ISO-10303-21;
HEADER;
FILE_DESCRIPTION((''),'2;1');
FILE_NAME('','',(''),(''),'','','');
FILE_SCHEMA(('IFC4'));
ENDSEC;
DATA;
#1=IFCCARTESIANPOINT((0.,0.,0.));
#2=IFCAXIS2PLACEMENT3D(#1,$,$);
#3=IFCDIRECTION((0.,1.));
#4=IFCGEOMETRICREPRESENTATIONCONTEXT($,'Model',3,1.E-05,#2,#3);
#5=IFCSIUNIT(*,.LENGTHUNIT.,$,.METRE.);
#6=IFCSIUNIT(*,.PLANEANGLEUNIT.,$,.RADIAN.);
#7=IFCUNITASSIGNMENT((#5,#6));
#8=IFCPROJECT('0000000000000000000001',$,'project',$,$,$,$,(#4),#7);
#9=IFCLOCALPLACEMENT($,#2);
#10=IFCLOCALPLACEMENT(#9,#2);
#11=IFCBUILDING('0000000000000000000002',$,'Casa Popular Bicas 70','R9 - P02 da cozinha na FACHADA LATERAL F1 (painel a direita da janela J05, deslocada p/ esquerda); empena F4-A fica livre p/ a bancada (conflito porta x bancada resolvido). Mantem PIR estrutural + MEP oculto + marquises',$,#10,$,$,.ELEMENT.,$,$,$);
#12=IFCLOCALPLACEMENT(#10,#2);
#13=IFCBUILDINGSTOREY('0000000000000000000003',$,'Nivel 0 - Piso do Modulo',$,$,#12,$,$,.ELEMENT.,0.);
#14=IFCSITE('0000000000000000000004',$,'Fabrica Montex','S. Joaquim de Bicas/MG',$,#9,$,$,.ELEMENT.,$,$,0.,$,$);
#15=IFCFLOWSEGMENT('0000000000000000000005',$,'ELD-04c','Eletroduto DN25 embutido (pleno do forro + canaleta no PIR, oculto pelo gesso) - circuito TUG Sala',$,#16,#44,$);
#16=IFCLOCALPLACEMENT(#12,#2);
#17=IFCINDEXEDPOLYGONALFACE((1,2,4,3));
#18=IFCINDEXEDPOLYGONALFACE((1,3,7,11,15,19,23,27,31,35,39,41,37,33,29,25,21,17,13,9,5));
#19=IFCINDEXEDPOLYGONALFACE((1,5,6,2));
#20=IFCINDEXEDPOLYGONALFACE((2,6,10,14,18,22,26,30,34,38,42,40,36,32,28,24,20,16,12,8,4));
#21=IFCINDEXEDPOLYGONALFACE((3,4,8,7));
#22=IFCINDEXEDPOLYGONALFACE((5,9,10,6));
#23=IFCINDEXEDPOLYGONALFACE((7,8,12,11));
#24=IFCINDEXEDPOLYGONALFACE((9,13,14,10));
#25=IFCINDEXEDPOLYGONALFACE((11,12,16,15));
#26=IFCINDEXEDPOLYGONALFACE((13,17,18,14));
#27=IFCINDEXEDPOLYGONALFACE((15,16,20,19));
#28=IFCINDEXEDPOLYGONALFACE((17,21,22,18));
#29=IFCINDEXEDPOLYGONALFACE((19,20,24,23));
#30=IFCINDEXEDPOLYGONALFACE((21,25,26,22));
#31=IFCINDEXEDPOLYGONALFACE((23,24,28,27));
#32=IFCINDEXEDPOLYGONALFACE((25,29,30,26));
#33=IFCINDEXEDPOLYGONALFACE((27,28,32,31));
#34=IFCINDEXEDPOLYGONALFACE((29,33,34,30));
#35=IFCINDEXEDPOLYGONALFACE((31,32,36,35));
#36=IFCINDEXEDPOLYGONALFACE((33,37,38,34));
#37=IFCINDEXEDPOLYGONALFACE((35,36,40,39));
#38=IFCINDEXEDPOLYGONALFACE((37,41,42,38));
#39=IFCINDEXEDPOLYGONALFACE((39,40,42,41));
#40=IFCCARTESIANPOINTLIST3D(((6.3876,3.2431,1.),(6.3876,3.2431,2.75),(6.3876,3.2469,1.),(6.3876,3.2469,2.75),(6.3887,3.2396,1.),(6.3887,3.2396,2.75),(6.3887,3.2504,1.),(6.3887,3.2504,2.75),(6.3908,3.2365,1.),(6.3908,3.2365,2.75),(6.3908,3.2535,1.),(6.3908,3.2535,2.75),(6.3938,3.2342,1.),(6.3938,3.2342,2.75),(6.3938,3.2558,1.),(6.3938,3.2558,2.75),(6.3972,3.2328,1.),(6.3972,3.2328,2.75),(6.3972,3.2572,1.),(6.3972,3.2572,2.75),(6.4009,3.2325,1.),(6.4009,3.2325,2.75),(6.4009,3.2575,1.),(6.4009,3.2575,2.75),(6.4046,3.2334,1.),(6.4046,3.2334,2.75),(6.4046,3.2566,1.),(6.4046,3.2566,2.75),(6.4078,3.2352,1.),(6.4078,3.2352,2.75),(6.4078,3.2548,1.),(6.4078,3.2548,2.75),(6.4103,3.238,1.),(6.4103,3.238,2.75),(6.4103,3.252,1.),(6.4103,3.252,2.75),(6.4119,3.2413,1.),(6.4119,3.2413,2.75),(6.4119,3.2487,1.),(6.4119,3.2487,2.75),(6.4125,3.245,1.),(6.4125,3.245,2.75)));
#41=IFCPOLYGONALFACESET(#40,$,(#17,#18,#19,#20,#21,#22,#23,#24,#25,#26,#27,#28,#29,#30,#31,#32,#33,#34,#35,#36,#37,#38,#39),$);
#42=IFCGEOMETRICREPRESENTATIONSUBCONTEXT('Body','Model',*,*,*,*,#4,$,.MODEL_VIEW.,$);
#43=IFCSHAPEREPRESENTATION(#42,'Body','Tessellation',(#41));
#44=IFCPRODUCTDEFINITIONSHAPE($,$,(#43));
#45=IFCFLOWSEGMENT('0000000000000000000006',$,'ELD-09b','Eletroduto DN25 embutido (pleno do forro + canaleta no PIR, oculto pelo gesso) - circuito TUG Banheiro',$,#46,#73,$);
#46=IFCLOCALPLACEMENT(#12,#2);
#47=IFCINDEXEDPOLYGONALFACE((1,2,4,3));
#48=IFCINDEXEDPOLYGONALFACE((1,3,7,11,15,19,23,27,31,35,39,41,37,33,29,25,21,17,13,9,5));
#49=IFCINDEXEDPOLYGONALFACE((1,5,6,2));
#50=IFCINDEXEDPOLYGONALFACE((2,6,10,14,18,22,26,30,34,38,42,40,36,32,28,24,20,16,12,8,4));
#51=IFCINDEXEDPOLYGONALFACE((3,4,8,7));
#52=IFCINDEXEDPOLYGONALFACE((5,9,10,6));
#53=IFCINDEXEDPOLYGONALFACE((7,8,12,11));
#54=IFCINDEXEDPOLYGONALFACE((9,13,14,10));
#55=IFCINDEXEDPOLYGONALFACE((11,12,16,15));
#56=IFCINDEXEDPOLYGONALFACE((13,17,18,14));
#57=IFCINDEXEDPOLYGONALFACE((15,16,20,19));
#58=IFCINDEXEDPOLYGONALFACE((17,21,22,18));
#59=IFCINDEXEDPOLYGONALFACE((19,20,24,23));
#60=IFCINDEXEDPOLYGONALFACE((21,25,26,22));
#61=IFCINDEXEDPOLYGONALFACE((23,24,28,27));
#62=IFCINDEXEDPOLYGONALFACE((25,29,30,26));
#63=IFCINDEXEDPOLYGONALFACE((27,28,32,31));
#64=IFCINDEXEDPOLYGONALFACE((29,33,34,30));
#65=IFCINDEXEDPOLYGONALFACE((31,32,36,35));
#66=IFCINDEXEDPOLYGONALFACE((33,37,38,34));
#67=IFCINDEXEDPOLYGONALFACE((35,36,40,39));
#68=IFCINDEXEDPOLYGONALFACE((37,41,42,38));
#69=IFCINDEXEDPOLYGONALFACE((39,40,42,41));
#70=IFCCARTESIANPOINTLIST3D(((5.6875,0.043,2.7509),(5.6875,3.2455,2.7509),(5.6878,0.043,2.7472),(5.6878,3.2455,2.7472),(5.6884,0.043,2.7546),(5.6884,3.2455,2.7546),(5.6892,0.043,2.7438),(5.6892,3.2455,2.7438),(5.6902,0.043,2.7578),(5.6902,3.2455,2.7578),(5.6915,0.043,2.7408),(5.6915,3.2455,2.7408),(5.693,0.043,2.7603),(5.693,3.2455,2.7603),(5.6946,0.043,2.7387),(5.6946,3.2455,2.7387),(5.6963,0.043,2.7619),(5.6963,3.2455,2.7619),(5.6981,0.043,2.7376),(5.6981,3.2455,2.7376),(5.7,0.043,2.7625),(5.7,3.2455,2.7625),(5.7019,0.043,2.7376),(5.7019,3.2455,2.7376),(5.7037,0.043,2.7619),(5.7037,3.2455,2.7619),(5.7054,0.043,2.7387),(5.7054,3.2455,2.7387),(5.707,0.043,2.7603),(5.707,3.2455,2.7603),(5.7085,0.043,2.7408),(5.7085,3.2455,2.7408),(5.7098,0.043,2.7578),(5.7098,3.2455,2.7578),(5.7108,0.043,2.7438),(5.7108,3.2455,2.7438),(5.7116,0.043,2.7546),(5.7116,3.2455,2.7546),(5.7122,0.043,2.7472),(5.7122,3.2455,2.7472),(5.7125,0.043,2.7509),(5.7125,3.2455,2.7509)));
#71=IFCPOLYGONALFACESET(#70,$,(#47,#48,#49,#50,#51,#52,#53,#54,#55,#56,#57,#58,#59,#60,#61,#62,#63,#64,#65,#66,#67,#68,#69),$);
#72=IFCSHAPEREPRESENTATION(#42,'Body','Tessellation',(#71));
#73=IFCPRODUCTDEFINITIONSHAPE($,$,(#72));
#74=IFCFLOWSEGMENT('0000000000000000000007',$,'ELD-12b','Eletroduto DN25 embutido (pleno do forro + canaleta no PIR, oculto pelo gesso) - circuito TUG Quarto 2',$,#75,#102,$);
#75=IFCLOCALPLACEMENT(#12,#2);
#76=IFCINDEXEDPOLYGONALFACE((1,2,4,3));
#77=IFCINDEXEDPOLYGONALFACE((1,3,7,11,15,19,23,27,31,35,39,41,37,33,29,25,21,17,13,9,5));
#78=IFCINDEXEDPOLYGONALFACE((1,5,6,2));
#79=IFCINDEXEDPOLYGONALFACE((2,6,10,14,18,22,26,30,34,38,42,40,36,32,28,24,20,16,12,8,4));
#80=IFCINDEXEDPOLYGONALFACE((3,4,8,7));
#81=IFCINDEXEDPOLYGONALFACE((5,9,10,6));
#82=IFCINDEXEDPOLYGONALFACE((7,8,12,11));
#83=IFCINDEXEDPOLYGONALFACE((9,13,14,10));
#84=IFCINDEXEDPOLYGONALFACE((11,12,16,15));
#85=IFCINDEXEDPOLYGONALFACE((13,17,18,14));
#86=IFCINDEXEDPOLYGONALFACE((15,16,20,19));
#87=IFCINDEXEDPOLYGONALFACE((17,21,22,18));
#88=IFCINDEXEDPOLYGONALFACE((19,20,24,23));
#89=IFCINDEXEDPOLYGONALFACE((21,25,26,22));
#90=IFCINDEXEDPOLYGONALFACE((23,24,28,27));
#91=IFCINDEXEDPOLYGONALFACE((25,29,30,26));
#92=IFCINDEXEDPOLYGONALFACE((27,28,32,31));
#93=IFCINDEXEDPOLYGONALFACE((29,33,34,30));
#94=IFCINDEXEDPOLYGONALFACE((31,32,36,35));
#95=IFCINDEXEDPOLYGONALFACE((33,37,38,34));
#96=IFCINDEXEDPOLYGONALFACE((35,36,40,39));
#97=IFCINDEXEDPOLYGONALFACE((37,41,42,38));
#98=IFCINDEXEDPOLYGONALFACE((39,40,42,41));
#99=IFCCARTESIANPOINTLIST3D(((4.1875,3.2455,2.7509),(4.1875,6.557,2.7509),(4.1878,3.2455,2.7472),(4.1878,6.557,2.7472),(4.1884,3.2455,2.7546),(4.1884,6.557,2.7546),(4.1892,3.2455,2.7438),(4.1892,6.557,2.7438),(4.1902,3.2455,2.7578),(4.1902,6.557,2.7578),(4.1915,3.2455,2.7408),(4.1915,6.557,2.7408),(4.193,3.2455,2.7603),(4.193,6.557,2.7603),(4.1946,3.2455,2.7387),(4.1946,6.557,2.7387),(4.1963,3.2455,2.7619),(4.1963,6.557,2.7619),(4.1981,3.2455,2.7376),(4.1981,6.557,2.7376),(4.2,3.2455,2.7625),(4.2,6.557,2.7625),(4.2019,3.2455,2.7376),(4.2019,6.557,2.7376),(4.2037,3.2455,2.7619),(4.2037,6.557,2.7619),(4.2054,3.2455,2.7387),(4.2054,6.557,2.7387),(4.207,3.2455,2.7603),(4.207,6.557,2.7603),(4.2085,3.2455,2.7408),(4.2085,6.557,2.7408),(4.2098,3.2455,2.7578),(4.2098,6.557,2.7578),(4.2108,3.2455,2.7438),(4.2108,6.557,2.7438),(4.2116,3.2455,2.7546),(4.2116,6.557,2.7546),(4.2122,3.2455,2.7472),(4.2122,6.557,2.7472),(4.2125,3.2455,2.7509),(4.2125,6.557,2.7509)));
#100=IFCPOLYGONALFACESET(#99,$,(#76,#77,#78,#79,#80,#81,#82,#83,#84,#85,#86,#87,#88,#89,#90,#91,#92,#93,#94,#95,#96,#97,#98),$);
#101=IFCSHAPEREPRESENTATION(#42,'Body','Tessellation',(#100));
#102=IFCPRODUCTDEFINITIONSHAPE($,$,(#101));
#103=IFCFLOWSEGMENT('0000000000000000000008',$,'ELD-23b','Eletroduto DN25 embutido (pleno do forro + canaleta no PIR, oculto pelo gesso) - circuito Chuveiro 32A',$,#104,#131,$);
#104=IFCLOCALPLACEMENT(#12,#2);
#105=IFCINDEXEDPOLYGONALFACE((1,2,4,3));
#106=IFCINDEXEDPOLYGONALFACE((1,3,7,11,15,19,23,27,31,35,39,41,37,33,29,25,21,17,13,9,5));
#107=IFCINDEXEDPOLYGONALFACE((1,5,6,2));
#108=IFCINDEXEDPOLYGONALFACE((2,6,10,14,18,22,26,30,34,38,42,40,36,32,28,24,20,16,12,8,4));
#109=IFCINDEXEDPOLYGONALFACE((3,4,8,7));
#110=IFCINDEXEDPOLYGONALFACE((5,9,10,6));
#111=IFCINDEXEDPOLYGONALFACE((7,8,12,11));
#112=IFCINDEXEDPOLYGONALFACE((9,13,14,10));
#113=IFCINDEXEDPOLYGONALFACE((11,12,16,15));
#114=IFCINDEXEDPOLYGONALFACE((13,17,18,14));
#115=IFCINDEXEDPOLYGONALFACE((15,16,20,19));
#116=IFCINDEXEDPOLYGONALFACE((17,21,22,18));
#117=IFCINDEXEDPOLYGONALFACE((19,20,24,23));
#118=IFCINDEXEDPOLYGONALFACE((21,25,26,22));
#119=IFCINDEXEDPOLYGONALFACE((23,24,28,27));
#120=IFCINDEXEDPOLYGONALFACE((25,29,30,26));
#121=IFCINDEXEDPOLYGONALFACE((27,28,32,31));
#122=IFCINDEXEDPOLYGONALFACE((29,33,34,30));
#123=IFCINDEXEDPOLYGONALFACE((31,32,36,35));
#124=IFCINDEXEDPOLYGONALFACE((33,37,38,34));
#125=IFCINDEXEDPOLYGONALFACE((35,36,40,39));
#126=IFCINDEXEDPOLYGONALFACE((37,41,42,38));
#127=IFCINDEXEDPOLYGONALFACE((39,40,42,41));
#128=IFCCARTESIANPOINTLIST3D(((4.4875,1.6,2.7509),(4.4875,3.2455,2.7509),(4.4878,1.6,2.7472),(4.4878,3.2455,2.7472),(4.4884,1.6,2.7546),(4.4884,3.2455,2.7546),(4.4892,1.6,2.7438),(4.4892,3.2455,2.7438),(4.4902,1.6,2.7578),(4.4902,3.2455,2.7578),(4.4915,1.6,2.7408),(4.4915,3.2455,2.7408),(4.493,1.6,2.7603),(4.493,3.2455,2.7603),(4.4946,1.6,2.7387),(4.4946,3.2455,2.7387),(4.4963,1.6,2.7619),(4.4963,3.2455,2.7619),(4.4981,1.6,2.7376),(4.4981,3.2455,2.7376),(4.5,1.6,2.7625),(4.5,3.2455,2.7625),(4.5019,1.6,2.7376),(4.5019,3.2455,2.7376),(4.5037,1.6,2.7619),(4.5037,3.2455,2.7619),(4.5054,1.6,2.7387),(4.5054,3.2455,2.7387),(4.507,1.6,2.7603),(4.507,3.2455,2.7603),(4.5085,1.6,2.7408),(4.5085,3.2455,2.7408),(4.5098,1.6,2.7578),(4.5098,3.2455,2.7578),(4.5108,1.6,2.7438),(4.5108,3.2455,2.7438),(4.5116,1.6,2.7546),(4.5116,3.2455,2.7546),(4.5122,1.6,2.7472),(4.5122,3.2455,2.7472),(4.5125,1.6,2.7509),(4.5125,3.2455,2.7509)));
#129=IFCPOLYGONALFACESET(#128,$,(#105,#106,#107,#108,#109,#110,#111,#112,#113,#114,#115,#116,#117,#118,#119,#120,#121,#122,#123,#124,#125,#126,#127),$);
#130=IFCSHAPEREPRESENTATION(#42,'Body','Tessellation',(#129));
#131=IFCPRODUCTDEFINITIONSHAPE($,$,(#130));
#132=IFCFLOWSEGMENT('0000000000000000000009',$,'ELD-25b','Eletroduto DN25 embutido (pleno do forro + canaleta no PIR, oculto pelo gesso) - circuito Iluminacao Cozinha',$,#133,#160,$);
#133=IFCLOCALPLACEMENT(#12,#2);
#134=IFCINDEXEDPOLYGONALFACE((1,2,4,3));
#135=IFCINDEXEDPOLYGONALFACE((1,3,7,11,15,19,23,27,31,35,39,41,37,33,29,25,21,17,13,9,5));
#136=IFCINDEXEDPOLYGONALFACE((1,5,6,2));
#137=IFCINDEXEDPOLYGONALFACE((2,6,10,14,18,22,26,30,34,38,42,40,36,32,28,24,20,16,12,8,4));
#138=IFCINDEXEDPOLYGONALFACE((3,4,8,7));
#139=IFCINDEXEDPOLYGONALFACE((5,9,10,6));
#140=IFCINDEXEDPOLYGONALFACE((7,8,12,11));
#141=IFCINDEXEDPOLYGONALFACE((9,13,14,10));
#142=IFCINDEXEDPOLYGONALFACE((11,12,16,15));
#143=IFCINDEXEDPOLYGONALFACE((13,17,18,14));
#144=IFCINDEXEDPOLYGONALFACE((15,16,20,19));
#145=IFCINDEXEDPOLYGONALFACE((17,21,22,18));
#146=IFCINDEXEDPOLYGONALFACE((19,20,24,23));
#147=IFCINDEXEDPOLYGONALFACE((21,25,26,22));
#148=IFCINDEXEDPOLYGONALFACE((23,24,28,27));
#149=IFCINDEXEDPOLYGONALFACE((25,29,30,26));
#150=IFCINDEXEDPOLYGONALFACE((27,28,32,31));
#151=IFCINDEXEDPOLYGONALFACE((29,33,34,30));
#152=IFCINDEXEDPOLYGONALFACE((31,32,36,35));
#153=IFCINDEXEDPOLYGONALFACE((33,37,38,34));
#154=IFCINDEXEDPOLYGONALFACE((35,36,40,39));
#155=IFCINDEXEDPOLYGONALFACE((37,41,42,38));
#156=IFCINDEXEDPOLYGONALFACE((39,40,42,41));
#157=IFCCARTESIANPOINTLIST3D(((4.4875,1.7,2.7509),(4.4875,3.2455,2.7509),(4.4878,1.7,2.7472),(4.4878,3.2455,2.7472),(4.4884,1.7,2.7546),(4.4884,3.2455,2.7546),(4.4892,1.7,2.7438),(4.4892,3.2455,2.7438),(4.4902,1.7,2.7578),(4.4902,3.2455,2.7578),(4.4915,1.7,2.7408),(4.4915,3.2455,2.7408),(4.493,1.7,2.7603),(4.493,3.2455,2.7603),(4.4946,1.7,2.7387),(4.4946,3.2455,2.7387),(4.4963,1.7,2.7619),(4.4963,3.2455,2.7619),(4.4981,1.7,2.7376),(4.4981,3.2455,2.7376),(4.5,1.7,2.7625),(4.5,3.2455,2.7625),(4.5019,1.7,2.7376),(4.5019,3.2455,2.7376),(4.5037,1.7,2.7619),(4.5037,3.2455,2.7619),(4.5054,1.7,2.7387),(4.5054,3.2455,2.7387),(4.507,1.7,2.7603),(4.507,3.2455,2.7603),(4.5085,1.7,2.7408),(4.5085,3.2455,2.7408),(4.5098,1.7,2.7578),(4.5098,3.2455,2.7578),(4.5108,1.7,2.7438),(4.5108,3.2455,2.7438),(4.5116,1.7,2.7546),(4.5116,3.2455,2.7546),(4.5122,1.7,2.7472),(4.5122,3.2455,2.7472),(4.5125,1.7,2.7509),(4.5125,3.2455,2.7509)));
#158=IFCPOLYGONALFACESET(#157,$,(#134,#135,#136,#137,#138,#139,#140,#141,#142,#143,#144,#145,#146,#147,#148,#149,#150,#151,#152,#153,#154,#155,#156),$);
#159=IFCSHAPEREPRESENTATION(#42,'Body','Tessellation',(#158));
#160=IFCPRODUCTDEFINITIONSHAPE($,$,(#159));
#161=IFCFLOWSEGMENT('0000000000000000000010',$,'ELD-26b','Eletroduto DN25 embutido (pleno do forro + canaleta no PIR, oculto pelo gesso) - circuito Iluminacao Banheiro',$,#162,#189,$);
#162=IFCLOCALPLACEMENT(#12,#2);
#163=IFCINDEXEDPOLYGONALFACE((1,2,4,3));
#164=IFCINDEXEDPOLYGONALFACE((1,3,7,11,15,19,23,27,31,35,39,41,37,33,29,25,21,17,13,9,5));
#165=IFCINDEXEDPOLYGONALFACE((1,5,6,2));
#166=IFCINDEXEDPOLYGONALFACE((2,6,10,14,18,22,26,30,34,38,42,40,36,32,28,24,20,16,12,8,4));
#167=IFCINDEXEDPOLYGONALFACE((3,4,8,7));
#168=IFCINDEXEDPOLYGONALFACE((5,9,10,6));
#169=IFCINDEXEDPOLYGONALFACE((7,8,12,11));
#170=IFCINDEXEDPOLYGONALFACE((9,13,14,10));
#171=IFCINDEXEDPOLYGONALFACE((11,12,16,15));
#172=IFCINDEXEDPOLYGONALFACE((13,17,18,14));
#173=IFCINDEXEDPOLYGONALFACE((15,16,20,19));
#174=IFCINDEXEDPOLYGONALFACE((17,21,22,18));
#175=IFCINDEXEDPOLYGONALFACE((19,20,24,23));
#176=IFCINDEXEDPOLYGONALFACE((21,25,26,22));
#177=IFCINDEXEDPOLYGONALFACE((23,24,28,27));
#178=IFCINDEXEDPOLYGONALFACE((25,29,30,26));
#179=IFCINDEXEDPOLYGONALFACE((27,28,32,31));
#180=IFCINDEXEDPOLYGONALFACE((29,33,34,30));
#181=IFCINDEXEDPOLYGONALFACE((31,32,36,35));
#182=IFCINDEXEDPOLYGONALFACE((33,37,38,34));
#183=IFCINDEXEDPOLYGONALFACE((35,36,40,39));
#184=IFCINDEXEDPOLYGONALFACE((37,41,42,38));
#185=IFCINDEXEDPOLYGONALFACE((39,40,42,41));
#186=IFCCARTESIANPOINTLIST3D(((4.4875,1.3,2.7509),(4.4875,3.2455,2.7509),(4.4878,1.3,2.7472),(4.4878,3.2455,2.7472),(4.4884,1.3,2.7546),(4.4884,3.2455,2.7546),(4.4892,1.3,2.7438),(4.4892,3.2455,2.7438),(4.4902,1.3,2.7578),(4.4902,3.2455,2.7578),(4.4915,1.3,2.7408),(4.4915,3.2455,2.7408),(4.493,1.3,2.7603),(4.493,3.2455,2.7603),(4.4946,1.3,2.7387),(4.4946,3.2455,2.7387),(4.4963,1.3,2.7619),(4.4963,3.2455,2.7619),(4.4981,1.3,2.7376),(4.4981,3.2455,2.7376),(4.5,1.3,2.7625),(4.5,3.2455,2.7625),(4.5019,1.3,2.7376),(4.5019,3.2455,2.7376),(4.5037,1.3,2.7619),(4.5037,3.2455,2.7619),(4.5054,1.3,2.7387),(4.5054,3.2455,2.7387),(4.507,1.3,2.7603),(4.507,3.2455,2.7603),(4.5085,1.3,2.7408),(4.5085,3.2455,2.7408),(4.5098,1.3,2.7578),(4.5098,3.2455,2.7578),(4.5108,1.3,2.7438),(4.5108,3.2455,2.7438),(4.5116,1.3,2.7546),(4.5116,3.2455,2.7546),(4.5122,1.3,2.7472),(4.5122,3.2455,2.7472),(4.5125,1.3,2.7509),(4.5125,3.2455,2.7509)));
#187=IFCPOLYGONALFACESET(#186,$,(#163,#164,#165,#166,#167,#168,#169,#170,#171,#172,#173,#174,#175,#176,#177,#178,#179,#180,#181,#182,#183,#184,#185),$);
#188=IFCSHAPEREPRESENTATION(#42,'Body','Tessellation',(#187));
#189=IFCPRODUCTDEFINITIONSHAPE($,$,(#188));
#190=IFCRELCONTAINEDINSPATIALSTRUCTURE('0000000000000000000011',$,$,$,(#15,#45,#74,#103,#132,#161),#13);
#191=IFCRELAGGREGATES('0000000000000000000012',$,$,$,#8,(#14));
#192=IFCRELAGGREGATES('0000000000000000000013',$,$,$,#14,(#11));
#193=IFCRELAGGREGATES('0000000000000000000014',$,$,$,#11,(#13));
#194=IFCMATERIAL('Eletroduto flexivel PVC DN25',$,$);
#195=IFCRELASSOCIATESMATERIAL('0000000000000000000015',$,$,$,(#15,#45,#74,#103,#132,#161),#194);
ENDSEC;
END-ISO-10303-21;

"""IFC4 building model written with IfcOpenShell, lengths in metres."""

from ifc_helpers import new_model, si_unit, direction, frame, origin, origin_2d, place, context, subcontext, project, spatial, circle, extrude, material, element, save


model = new_model("IFC4")

# Units and contexts
model_context = context("Model", 3, precision=1e-05, world=origin(), true_north=direction((0.0, 1.0)))
body_context = subcontext(model_context, "Body", "Model", "MODEL_VIEW")
ifc_project = project(units=[si_unit("LENGTHUNIT", "METRE"), si_unit("PLANEANGLEUNIT", "RADIAN")], contexts=[model_context])

# Site, building, storey
site_placement = place(None, origin())
site = spatial("IfcSite", under=ifc_project, at=site_placement, Name="Fabrica Montex", Description="S. Joaquim de Bicas/MG", CompositionType="ELEMENT", RefElevation=0.0)
building_placement = place(site_placement, origin())
building = spatial("IfcBuilding", under=site, at=building_placement, Name="Casa Popular Bicas 70", Description="R9 - P02 da cozinha na FACHADA LATERAL F1 (painel a direita da janela J05, deslocada p/ esquerda); empena F4-A fica livre p/ a bancada (conflito porta x bancada resolvido). Mantem PIR estrutural + MEP oculto + marquises", CompositionType="ELEMENT")
storey_placement = place(building_placement, origin())
storey = spatial("IfcBuildingStorey", under=building, at=storey_placement, Name="Nivel 0 - Piso do Modulo", CompositionType="ELEMENT", Elevation=0.0)

# Shared definitions
ifc_material_1 = material(Name="Eletroduto flexivel PVC DN25")

# Flow segments
flow_segment_1_placement = place(storey_placement, frame((6.4, 3.245, 2.75), z_axis=(0.0, 0.0, -1.0), x_axis=(1.0, 0.0, 0.0)))
element("IfcFlowSegment", 1, at=flow_segment_1_placement, inside=storey, material=ifc_material_1, Name="ELD-04c", Description="Eletroduto DN25 embutido (pleno do forro + canaleta no PIR, oculto pelo gesso) - circuito TUG Sala", context=body_context, shape_type="SweptSolid", body=[
    extrude(circle(Radius=0.0125, at=origin_2d()), origin(), (0.0, 0.0, 1.0), 1.75),
])
flow_segment_2_placement = place(storey_placement, frame((5.7, 3.2455, 2.75), z_axis=(0.0, -1.0, 0.0), x_axis=(0.0, 0.0, 1.0)))
element("IfcFlowSegment", 2, at=flow_segment_2_placement, inside=storey, material=ifc_material_1, Name="ELD-09b", Description="Eletroduto DN25 embutido (pleno do forro + canaleta no PIR, oculto pelo gesso) - circuito TUG Banheiro", context=body_context, shape_type="SweptSolid", body=[
    extrude(circle(Radius=0.0125, at=origin_2d()), origin(), (0.0, 0.0, 1.0), 3.2025),
])
flow_segment_3_placement = place(storey_placement, frame((4.2, 3.2455, 2.75), z_axis=(0.0, 1.0, 0.0), x_axis=(0.0, 0.0, 1.0)))
element("IfcFlowSegment", 3, at=flow_segment_3_placement, inside=storey, material=ifc_material_1, Name="ELD-12b", Description="Eletroduto DN25 embutido (pleno do forro + canaleta no PIR, oculto pelo gesso) - circuito TUG Quarto 2", context=body_context, shape_type="SweptSolid", body=[
    extrude(circle(Radius=0.0125, at=origin_2d()), origin(), (0.0, 0.0, 1.0), 3.3115),
])
flow_segment_4_placement = place(storey_placement, frame((4.5, 3.2455, 2.75), z_axis=(0.0, -1.0, 0.0), x_axis=(0.0, 0.0, 1.0)))
element("IfcFlowSegment", 4, at=flow_segment_4_placement, inside=storey, material=ifc_material_1, Name="ELD-23b", Description="Eletroduto DN25 embutido (pleno do forro + canaleta no PIR, oculto pelo gesso) - circuito Chuveiro 32A", context=body_context, shape_type="SweptSolid", body=[
    extrude(circle(Radius=0.0125, at=origin_2d()), origin(), (0.0, 0.0, 1.0), 1.6455),
])
flow_segment_5_placement = place(storey_placement, frame((4.5, 3.2455, 2.75), z_axis=(0.0, -1.0, 0.0), x_axis=(0.0, 0.0, 1.0)))
element("IfcFlowSegment", 5, at=flow_segment_5_placement, inside=storey, material=ifc_material_1, Name="ELD-25b", Description="Eletroduto DN25 embutido (pleno do forro + canaleta no PIR, oculto pelo gesso) - circuito Iluminacao Cozinha", context=body_context, shape_type="SweptSolid", body=[
    extrude(circle(Radius=0.0125, at=origin_2d()), origin(), (0.0, 0.0, 1.0), 1.5455),
])
flow_segment_6_placement = place(storey_placement, frame((4.5, 3.2455, 2.75), z_axis=(0.0, -1.0, 0.0), x_axis=(0.0, 0.0, 1.0)))
element("IfcFlowSegment", 6, at=flow_segment_6_placement, inside=storey, material=ifc_material_1, Name="ELD-26b", Description="Eletroduto DN25 embutido (pleno do forro + canaleta no PIR, oculto pelo gesso) - circuito Iluminacao Banheiro", context=body_context, shape_type="SweptSolid", body=[
    extrude(circle(Radius=0.0125, at=origin_2d()), origin(), (0.0, 0.0, 1.0), 1.9455),
])

save(model, "model.ifc")
